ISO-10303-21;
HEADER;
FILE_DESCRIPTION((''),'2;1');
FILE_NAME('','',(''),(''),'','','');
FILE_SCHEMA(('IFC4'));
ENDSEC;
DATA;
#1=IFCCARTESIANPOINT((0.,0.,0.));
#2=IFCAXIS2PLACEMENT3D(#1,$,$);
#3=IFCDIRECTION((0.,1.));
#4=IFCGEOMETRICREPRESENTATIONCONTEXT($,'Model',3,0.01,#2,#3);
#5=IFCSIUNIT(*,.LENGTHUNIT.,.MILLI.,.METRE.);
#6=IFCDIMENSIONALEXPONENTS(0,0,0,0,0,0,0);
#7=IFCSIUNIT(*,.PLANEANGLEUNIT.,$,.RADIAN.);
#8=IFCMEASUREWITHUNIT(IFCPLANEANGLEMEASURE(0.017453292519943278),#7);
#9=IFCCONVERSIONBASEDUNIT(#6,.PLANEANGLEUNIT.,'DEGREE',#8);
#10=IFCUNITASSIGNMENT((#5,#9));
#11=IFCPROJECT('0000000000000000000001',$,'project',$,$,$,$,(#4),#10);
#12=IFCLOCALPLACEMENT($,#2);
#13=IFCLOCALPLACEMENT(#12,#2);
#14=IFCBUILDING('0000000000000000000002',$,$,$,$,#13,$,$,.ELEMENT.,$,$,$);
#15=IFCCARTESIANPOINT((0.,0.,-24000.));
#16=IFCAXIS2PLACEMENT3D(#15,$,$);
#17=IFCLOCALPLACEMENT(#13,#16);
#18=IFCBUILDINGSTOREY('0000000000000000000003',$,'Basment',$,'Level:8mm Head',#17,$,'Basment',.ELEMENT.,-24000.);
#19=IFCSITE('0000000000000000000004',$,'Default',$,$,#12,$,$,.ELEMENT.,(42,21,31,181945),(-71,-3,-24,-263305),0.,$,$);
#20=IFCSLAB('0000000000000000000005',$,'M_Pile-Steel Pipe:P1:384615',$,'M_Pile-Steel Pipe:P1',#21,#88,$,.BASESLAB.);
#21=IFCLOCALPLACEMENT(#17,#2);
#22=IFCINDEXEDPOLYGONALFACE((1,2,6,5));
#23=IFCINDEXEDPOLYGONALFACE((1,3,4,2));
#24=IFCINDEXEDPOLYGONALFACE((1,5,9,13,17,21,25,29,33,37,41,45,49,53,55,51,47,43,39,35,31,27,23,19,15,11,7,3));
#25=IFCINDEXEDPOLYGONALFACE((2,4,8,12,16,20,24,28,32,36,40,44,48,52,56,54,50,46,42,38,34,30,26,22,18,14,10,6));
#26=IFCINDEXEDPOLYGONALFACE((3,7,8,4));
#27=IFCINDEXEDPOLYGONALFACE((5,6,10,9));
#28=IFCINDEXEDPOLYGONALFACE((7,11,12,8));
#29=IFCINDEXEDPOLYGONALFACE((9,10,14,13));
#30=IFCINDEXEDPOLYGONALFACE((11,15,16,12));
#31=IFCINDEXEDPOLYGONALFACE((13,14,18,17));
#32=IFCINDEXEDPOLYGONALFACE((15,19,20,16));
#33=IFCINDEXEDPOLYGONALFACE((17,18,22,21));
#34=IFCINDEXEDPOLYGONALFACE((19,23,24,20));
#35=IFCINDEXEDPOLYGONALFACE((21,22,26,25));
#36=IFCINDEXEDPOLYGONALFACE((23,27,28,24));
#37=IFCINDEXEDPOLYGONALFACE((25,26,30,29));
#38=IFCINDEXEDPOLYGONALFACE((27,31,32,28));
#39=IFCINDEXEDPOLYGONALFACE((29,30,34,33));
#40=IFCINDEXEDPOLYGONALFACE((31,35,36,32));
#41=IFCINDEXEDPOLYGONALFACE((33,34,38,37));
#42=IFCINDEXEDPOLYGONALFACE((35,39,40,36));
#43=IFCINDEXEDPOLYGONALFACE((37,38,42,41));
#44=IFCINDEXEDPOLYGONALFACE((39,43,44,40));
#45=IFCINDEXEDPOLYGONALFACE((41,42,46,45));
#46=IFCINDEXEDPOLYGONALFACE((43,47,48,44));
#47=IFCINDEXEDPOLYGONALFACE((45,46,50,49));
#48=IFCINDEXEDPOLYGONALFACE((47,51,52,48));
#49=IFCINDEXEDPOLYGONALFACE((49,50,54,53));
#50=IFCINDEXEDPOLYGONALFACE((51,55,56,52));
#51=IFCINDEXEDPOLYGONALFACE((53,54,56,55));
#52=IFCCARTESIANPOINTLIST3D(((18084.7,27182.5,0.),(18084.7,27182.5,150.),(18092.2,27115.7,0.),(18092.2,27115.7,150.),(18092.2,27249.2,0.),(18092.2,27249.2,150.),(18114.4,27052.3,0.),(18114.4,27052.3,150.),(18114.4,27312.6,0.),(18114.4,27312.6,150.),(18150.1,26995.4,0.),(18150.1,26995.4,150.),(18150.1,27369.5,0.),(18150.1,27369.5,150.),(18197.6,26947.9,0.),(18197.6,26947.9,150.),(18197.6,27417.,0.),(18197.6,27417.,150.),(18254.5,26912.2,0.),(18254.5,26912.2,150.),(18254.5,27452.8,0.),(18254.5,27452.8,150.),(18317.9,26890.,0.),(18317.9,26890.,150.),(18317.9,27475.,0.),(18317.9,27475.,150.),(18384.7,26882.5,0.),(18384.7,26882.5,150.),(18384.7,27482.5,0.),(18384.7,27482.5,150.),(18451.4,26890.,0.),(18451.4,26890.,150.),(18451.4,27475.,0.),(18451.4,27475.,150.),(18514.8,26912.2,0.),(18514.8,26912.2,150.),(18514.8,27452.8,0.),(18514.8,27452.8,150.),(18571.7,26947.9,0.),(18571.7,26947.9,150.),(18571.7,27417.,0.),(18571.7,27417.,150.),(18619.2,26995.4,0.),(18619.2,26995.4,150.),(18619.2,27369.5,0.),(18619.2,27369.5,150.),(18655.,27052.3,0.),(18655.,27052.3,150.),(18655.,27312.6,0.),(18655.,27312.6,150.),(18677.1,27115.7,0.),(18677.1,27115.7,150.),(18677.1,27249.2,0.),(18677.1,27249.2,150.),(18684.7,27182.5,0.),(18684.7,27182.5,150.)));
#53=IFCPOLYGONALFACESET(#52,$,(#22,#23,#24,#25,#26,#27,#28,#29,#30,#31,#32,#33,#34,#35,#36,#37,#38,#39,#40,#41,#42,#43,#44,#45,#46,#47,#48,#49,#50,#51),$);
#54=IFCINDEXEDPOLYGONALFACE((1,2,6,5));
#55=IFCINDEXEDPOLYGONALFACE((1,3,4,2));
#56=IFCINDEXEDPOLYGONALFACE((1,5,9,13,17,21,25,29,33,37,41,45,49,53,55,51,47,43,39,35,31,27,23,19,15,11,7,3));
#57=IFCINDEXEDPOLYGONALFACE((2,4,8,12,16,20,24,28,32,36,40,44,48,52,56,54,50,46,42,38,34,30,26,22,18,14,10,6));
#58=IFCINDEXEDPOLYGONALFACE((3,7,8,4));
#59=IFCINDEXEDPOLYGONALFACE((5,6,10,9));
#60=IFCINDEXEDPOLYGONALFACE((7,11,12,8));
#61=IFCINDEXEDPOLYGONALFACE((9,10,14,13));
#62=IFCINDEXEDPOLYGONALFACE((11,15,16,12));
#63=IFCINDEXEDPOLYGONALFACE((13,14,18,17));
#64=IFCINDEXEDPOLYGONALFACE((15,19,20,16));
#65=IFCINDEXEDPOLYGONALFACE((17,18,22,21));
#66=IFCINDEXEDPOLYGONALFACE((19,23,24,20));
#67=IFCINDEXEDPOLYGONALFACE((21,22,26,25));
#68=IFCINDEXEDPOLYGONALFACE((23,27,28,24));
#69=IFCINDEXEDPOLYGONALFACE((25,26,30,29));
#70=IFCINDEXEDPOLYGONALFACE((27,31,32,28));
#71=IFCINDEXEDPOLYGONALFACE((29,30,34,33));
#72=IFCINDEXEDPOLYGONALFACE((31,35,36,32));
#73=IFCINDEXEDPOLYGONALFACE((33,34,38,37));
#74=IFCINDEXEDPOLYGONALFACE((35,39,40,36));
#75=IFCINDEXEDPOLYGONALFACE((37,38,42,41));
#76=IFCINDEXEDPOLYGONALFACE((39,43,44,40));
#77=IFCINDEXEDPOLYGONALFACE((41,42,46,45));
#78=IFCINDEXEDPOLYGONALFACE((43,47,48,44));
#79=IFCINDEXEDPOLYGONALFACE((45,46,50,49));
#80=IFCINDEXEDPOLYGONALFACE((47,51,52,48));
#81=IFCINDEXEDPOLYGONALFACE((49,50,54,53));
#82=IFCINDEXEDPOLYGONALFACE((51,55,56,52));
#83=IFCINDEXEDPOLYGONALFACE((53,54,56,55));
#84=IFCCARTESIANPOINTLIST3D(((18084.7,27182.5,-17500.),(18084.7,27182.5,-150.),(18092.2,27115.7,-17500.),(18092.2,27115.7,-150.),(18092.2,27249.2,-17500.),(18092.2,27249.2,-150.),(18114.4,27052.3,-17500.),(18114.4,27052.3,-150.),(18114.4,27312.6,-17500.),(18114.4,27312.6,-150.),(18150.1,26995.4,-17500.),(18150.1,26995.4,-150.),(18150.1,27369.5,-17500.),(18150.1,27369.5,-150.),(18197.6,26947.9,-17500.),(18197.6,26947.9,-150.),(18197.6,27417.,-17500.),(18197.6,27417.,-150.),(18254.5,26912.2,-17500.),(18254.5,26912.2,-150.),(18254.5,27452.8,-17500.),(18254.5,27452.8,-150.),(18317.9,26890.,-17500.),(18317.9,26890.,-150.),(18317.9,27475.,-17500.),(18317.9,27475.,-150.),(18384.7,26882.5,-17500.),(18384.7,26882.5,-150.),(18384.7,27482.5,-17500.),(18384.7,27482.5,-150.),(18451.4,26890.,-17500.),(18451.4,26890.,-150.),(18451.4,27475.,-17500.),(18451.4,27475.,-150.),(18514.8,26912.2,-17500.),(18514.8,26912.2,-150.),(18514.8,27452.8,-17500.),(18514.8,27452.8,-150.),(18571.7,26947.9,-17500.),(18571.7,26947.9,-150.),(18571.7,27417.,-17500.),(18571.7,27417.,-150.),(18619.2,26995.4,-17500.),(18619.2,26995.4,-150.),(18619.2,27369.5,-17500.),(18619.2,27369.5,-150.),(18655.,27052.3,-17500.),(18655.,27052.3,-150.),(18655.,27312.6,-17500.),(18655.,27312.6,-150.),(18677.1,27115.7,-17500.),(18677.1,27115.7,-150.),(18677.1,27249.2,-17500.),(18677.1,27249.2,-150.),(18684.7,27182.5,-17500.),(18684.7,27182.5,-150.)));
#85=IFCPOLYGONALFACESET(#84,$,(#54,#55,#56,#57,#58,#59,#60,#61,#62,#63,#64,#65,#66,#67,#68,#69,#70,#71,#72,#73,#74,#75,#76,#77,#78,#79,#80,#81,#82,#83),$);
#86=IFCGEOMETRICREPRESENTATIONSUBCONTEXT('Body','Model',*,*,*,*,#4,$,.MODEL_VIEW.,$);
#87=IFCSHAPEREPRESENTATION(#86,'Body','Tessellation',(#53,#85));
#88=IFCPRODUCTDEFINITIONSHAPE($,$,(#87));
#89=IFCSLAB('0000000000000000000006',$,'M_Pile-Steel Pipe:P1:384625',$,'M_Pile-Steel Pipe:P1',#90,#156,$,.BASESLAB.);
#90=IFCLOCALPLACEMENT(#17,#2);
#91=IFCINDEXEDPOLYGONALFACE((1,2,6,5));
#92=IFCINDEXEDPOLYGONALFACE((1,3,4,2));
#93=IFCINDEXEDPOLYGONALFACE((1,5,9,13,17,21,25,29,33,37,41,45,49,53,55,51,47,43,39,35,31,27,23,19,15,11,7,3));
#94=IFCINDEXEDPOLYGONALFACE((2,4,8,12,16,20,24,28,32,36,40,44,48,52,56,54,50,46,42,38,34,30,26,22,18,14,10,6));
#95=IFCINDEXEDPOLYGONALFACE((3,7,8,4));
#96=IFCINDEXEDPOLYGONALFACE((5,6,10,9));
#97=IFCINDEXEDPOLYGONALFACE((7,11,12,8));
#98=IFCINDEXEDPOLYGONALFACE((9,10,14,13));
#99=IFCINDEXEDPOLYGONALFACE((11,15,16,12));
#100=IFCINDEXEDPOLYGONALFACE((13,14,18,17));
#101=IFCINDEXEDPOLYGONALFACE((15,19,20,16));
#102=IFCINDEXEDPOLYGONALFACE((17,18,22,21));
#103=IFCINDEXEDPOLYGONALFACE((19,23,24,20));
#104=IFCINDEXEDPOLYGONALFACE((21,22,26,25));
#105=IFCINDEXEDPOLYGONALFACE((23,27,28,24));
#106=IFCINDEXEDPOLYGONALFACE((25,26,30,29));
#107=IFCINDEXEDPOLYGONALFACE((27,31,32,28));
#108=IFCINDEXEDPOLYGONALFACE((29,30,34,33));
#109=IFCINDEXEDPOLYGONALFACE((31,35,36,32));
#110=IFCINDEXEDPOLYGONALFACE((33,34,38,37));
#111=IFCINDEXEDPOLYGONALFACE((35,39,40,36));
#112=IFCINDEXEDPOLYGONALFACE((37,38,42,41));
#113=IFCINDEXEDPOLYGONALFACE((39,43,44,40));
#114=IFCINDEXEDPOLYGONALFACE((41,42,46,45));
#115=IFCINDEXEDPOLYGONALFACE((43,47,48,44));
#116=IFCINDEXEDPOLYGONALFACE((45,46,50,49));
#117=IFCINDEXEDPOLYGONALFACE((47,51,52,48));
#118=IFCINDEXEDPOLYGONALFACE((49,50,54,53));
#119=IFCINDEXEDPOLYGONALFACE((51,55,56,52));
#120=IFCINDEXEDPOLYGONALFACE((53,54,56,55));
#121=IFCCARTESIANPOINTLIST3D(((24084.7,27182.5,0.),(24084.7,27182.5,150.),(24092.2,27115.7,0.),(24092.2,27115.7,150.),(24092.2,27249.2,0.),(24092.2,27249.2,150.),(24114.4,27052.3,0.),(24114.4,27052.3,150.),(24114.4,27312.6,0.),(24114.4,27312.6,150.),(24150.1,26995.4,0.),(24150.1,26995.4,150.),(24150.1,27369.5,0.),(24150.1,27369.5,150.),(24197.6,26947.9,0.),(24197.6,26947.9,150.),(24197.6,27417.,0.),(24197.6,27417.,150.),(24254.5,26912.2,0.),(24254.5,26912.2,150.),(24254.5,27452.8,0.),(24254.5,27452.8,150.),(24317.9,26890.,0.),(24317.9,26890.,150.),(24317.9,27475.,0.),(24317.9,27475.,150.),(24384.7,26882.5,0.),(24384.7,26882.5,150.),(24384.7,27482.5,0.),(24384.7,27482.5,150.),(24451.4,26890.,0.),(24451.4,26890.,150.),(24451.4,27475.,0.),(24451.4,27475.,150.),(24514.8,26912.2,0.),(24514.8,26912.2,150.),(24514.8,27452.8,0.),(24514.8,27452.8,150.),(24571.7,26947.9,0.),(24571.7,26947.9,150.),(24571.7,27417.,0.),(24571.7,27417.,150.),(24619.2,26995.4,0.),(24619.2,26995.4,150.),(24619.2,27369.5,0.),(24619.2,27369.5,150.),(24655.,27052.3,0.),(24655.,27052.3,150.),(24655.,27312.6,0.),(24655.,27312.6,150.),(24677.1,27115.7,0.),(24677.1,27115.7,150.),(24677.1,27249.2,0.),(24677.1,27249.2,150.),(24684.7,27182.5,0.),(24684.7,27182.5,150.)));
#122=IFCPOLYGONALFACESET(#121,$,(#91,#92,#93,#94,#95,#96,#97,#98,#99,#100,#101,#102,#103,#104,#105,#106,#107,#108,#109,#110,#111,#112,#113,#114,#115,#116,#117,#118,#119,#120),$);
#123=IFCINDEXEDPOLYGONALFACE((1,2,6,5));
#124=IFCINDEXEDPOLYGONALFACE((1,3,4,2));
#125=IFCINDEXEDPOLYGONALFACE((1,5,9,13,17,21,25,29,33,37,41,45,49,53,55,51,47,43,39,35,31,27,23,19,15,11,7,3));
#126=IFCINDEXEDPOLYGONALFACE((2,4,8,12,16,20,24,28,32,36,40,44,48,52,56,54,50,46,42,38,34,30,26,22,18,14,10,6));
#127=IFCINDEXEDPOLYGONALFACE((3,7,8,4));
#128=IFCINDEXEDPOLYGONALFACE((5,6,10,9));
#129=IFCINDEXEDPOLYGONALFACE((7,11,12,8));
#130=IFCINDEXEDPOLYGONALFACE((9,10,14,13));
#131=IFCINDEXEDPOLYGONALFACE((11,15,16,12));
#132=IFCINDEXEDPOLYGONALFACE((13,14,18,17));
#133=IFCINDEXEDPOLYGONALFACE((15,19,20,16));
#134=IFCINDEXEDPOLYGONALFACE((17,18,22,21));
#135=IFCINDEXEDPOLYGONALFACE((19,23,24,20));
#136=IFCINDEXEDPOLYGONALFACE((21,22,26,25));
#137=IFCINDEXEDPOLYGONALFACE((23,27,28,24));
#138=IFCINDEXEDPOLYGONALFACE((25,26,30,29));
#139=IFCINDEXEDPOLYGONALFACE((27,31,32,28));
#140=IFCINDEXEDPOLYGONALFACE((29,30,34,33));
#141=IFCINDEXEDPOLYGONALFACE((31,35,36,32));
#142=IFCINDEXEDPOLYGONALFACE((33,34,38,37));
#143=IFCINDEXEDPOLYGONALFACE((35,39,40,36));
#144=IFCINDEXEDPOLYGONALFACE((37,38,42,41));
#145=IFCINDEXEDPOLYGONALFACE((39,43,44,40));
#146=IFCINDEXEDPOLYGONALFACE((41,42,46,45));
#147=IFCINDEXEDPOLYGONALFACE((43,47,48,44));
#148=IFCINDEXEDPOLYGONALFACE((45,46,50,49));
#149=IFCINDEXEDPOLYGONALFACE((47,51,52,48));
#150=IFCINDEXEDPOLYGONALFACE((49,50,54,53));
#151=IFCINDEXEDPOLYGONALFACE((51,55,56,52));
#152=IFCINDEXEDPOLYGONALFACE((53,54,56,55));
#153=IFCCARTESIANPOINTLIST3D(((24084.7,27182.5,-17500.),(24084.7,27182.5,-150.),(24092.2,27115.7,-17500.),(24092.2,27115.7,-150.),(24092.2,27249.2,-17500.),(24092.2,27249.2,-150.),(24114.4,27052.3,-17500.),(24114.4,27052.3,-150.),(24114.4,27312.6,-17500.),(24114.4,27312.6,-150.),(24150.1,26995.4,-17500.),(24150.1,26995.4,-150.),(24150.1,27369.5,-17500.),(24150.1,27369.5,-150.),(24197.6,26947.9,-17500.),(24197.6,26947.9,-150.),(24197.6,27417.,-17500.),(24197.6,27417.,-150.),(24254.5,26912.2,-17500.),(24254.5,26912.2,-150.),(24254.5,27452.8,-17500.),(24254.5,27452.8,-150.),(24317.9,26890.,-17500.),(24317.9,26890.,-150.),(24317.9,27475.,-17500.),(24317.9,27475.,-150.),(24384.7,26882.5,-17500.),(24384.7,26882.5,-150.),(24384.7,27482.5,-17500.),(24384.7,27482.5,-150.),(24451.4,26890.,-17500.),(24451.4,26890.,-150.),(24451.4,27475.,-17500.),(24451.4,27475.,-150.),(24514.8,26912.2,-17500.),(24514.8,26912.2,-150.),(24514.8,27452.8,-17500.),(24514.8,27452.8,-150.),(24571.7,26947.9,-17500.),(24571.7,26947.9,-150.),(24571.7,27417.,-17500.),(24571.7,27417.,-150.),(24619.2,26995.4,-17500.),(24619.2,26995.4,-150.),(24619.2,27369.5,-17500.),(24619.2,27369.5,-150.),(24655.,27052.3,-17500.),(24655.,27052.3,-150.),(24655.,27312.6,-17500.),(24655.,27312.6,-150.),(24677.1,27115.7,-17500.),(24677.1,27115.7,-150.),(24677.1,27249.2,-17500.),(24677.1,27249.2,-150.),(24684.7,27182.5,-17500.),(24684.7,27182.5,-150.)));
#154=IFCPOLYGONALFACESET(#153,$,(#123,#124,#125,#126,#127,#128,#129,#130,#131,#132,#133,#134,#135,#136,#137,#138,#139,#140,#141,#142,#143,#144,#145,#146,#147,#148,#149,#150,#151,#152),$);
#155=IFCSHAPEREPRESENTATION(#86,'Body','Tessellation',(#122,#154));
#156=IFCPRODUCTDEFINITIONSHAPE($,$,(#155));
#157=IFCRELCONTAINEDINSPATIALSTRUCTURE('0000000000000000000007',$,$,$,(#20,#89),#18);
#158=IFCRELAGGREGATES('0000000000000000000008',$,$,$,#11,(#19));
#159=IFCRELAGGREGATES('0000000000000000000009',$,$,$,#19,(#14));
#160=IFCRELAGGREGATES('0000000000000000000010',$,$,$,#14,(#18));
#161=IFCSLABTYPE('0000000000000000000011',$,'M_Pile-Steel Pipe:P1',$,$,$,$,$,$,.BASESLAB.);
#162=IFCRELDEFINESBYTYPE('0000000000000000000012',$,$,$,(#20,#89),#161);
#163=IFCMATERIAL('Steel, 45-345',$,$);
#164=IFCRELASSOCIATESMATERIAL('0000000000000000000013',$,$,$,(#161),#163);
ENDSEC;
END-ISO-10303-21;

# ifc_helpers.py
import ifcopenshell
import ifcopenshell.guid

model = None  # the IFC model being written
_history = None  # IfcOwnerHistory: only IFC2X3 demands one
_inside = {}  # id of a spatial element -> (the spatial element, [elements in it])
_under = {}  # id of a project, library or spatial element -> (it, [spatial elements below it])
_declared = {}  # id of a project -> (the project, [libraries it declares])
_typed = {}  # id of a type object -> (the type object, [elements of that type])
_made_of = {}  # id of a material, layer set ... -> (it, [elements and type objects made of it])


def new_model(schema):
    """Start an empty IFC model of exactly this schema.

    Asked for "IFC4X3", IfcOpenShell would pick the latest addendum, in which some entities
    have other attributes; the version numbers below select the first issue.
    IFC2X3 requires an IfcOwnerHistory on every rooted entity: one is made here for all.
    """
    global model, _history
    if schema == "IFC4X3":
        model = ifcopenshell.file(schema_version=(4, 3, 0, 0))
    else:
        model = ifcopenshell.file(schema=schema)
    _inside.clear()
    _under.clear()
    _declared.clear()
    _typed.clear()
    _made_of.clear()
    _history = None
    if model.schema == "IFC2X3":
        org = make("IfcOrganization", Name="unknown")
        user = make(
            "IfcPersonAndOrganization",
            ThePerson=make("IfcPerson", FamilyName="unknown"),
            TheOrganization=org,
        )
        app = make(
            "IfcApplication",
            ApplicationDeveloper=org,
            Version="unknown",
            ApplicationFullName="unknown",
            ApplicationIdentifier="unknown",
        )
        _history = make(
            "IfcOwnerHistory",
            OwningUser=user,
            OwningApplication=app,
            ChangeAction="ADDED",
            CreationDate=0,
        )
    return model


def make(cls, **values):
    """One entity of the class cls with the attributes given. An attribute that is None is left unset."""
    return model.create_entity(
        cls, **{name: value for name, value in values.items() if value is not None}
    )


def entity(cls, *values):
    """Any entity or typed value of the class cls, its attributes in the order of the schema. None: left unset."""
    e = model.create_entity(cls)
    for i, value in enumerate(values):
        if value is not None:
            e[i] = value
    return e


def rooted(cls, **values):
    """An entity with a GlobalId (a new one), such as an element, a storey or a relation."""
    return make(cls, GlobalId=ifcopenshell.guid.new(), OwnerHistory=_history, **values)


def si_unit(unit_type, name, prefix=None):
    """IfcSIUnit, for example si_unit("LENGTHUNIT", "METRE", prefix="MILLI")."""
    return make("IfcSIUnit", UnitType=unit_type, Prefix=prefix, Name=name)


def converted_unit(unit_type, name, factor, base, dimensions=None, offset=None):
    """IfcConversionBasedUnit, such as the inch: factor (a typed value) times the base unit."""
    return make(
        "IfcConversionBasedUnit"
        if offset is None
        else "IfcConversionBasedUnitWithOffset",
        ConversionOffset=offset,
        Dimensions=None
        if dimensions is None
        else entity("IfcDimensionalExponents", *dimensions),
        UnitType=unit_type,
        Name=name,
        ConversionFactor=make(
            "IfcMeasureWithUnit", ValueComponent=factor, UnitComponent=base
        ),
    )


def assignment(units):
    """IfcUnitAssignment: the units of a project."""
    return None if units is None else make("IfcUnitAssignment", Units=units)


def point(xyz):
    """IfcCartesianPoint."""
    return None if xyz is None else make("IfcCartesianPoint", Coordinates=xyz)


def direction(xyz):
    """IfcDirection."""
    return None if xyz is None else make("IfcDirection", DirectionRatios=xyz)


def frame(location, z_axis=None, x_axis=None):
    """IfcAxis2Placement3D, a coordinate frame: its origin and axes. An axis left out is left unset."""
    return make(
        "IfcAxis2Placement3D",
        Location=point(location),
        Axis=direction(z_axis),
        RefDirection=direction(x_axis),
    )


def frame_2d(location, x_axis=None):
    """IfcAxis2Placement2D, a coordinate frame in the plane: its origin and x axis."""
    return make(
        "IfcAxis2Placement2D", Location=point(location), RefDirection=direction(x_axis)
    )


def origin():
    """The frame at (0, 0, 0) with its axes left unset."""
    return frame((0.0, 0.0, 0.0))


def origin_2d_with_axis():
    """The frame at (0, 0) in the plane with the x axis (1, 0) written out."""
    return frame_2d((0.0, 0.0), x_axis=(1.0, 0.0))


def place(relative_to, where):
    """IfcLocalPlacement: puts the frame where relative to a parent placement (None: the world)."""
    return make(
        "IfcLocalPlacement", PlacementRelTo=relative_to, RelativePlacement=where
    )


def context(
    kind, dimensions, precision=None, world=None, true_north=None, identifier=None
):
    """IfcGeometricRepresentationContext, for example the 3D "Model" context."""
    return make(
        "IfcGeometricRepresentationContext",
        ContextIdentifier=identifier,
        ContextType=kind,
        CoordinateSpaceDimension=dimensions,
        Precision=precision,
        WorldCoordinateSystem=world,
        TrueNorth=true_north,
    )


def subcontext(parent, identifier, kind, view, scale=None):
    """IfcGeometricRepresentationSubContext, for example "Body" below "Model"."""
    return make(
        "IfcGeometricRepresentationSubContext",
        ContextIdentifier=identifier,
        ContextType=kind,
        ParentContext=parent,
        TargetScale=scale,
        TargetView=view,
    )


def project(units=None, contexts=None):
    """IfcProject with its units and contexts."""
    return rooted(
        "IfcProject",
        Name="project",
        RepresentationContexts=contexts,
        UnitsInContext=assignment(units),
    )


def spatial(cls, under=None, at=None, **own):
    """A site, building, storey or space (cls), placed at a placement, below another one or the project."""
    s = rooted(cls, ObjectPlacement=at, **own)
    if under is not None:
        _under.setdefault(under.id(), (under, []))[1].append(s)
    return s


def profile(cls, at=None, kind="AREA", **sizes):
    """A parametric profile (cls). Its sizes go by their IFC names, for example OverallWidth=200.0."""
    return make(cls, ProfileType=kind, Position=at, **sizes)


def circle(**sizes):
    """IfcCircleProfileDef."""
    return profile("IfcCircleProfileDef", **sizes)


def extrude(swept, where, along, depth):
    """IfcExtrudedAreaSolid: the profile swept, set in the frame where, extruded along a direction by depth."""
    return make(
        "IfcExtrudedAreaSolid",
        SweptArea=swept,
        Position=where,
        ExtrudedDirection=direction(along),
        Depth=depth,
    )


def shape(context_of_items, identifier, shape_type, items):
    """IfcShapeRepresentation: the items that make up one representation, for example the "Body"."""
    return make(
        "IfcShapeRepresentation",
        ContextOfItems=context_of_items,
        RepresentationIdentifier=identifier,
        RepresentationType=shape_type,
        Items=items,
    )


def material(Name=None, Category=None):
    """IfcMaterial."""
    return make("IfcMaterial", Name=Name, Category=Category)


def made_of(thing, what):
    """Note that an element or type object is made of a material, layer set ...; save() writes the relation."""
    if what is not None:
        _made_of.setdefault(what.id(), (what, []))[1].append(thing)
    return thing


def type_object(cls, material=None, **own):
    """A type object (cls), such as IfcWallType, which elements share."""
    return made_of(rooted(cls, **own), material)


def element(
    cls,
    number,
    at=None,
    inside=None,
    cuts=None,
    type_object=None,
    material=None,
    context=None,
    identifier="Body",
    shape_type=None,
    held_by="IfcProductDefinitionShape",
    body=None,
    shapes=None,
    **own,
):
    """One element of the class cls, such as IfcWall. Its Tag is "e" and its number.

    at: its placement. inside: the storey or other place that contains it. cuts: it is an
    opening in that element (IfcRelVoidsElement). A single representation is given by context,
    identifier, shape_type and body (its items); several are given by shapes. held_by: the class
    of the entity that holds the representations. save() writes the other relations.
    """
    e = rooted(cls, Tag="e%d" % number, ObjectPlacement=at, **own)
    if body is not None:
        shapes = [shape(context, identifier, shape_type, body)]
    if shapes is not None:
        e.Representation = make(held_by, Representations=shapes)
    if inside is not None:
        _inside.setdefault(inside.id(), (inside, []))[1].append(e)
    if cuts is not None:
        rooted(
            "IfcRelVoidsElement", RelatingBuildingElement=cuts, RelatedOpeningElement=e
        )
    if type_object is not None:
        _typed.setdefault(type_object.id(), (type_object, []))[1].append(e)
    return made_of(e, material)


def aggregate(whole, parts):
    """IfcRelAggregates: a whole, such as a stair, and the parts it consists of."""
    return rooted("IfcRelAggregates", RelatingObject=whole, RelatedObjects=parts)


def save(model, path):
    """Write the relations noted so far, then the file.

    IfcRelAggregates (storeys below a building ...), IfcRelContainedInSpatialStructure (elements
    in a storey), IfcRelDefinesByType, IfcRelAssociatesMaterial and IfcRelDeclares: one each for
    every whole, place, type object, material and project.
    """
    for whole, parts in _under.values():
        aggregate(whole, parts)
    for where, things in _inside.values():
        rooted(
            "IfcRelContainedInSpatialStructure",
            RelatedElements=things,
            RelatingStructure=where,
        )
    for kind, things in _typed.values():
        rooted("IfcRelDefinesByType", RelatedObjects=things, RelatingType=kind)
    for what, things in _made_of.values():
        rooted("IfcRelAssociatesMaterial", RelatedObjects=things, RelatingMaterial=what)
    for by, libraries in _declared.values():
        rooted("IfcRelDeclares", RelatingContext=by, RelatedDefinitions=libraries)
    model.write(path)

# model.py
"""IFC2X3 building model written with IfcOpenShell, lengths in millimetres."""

from ifc_helpers import new_model, entity, si_unit, converted_unit, direction, frame, frame_2d, origin, origin_2d_with_axis, place, context, subcontext, project, spatial, circle, extrude, material, type_object, element, save


model = new_model("IFC2X3")

# Units and contexts
model_context = context("Model", 3, precision=0.01, world=origin(), true_north=direction((0.0, 1.0)))
body_context = subcontext(model_context, "Body", "Model", "MODEL_VIEW")
ifc_project = project(units=[si_unit("LENGTHUNIT", "METRE", prefix="MILLI"), converted_unit("PLANEANGLEUNIT", "DEGREE", entity("IfcPlaneAngleMeasure", 0.017453292519943278), si_unit("PLANEANGLEUNIT", "RADIAN"), dimensions=[0, 0, 0, 0, 0, 0, 0])], contexts=[model_context])

# Site, building, storey
site_placement = place(None, origin())
site = spatial("IfcSite", under=ifc_project, at=site_placement, Name="Default", CompositionType="ELEMENT", RefLatitude=(42, 21, 31, 181945), RefLongitude=(-71, -3, -24, -263305), RefElevation=0.0)
building_placement = place(site_placement, origin())
building = spatial("IfcBuilding", under=site, at=building_placement, CompositionType="ELEMENT")
storey_placement = place(building_placement, frame((0.0, 0.0, -24000.0)))
storey = spatial("IfcBuildingStorey", under=building, at=storey_placement, Name="Basment", ObjectType="Level:8mm Head", LongName="Basment", CompositionType="ELEMENT", Elevation=-24000.0)

# Slabs
ifc_material_1 = material(Name="Steel, 45-345")
slab_type_1 = type_object("IfcSlabType", Name="M_Pile-Steel Pipe:P1", PredefinedType="BASESLAB", material=ifc_material_1)
slab_1_placement = place(storey_placement, origin())
element("IfcSlab", 1, at=slab_1_placement, inside=storey, type_object=slab_type_1, Name="M_Pile-Steel Pipe:P1:384615", ObjectType="M_Pile-Steel Pipe:P1", PredefinedType="BASESLAB", context=body_context, shape_type="SweptSolid", body=[
    extrude(circle(Radius=300.0, at=frame_2d((0.0, 0.0), x_axis=(1.0, 0.0))), frame((18384.7, 27182.5, 0.0), z_axis=(0.0, 0.0, 1.0), x_axis=(0.0, 1.0, 0.0)), (0.0, 0.0, 1.0), 150.0),
    extrude(circle(Radius=300.0, at=frame_2d((0.0, 0.0), x_axis=(1.0, 0.0))), frame((18384.7, 27182.5, -17500.0), z_axis=(0.0, 0.0, 1.0), x_axis=(0.0, 1.0, 0.0)), (0.0, 0.0, 1.0), 17350.0),
])
slab_2_placement = place(storey_placement, origin())
element("IfcSlab", 2, at=slab_2_placement, inside=storey, type_object=slab_type_1, Name="M_Pile-Steel Pipe:P1:384625", ObjectType="M_Pile-Steel Pipe:P1", PredefinedType="BASESLAB", context=body_context, shape_type="SweptSolid", body=[
    extrude(circle(Radius=300.0, at=origin_2d_with_axis()), frame((24384.7, 27182.5, 0.0), z_axis=(0.0, 0.0, 1.0), x_axis=(0.0, 1.0, 0.0)), (0.0, 0.0, 1.0), 150.0),
    extrude(circle(Radius=300.0, at=origin_2d_with_axis()), frame((24384.7, 27182.5, -17500.0), z_axis=(0.0, 0.0, 1.0), x_axis=(0.0, 1.0, 0.0)), (0.0, 0.0, 1.0), 17350.0),
])

save(model, "model.ifc")
